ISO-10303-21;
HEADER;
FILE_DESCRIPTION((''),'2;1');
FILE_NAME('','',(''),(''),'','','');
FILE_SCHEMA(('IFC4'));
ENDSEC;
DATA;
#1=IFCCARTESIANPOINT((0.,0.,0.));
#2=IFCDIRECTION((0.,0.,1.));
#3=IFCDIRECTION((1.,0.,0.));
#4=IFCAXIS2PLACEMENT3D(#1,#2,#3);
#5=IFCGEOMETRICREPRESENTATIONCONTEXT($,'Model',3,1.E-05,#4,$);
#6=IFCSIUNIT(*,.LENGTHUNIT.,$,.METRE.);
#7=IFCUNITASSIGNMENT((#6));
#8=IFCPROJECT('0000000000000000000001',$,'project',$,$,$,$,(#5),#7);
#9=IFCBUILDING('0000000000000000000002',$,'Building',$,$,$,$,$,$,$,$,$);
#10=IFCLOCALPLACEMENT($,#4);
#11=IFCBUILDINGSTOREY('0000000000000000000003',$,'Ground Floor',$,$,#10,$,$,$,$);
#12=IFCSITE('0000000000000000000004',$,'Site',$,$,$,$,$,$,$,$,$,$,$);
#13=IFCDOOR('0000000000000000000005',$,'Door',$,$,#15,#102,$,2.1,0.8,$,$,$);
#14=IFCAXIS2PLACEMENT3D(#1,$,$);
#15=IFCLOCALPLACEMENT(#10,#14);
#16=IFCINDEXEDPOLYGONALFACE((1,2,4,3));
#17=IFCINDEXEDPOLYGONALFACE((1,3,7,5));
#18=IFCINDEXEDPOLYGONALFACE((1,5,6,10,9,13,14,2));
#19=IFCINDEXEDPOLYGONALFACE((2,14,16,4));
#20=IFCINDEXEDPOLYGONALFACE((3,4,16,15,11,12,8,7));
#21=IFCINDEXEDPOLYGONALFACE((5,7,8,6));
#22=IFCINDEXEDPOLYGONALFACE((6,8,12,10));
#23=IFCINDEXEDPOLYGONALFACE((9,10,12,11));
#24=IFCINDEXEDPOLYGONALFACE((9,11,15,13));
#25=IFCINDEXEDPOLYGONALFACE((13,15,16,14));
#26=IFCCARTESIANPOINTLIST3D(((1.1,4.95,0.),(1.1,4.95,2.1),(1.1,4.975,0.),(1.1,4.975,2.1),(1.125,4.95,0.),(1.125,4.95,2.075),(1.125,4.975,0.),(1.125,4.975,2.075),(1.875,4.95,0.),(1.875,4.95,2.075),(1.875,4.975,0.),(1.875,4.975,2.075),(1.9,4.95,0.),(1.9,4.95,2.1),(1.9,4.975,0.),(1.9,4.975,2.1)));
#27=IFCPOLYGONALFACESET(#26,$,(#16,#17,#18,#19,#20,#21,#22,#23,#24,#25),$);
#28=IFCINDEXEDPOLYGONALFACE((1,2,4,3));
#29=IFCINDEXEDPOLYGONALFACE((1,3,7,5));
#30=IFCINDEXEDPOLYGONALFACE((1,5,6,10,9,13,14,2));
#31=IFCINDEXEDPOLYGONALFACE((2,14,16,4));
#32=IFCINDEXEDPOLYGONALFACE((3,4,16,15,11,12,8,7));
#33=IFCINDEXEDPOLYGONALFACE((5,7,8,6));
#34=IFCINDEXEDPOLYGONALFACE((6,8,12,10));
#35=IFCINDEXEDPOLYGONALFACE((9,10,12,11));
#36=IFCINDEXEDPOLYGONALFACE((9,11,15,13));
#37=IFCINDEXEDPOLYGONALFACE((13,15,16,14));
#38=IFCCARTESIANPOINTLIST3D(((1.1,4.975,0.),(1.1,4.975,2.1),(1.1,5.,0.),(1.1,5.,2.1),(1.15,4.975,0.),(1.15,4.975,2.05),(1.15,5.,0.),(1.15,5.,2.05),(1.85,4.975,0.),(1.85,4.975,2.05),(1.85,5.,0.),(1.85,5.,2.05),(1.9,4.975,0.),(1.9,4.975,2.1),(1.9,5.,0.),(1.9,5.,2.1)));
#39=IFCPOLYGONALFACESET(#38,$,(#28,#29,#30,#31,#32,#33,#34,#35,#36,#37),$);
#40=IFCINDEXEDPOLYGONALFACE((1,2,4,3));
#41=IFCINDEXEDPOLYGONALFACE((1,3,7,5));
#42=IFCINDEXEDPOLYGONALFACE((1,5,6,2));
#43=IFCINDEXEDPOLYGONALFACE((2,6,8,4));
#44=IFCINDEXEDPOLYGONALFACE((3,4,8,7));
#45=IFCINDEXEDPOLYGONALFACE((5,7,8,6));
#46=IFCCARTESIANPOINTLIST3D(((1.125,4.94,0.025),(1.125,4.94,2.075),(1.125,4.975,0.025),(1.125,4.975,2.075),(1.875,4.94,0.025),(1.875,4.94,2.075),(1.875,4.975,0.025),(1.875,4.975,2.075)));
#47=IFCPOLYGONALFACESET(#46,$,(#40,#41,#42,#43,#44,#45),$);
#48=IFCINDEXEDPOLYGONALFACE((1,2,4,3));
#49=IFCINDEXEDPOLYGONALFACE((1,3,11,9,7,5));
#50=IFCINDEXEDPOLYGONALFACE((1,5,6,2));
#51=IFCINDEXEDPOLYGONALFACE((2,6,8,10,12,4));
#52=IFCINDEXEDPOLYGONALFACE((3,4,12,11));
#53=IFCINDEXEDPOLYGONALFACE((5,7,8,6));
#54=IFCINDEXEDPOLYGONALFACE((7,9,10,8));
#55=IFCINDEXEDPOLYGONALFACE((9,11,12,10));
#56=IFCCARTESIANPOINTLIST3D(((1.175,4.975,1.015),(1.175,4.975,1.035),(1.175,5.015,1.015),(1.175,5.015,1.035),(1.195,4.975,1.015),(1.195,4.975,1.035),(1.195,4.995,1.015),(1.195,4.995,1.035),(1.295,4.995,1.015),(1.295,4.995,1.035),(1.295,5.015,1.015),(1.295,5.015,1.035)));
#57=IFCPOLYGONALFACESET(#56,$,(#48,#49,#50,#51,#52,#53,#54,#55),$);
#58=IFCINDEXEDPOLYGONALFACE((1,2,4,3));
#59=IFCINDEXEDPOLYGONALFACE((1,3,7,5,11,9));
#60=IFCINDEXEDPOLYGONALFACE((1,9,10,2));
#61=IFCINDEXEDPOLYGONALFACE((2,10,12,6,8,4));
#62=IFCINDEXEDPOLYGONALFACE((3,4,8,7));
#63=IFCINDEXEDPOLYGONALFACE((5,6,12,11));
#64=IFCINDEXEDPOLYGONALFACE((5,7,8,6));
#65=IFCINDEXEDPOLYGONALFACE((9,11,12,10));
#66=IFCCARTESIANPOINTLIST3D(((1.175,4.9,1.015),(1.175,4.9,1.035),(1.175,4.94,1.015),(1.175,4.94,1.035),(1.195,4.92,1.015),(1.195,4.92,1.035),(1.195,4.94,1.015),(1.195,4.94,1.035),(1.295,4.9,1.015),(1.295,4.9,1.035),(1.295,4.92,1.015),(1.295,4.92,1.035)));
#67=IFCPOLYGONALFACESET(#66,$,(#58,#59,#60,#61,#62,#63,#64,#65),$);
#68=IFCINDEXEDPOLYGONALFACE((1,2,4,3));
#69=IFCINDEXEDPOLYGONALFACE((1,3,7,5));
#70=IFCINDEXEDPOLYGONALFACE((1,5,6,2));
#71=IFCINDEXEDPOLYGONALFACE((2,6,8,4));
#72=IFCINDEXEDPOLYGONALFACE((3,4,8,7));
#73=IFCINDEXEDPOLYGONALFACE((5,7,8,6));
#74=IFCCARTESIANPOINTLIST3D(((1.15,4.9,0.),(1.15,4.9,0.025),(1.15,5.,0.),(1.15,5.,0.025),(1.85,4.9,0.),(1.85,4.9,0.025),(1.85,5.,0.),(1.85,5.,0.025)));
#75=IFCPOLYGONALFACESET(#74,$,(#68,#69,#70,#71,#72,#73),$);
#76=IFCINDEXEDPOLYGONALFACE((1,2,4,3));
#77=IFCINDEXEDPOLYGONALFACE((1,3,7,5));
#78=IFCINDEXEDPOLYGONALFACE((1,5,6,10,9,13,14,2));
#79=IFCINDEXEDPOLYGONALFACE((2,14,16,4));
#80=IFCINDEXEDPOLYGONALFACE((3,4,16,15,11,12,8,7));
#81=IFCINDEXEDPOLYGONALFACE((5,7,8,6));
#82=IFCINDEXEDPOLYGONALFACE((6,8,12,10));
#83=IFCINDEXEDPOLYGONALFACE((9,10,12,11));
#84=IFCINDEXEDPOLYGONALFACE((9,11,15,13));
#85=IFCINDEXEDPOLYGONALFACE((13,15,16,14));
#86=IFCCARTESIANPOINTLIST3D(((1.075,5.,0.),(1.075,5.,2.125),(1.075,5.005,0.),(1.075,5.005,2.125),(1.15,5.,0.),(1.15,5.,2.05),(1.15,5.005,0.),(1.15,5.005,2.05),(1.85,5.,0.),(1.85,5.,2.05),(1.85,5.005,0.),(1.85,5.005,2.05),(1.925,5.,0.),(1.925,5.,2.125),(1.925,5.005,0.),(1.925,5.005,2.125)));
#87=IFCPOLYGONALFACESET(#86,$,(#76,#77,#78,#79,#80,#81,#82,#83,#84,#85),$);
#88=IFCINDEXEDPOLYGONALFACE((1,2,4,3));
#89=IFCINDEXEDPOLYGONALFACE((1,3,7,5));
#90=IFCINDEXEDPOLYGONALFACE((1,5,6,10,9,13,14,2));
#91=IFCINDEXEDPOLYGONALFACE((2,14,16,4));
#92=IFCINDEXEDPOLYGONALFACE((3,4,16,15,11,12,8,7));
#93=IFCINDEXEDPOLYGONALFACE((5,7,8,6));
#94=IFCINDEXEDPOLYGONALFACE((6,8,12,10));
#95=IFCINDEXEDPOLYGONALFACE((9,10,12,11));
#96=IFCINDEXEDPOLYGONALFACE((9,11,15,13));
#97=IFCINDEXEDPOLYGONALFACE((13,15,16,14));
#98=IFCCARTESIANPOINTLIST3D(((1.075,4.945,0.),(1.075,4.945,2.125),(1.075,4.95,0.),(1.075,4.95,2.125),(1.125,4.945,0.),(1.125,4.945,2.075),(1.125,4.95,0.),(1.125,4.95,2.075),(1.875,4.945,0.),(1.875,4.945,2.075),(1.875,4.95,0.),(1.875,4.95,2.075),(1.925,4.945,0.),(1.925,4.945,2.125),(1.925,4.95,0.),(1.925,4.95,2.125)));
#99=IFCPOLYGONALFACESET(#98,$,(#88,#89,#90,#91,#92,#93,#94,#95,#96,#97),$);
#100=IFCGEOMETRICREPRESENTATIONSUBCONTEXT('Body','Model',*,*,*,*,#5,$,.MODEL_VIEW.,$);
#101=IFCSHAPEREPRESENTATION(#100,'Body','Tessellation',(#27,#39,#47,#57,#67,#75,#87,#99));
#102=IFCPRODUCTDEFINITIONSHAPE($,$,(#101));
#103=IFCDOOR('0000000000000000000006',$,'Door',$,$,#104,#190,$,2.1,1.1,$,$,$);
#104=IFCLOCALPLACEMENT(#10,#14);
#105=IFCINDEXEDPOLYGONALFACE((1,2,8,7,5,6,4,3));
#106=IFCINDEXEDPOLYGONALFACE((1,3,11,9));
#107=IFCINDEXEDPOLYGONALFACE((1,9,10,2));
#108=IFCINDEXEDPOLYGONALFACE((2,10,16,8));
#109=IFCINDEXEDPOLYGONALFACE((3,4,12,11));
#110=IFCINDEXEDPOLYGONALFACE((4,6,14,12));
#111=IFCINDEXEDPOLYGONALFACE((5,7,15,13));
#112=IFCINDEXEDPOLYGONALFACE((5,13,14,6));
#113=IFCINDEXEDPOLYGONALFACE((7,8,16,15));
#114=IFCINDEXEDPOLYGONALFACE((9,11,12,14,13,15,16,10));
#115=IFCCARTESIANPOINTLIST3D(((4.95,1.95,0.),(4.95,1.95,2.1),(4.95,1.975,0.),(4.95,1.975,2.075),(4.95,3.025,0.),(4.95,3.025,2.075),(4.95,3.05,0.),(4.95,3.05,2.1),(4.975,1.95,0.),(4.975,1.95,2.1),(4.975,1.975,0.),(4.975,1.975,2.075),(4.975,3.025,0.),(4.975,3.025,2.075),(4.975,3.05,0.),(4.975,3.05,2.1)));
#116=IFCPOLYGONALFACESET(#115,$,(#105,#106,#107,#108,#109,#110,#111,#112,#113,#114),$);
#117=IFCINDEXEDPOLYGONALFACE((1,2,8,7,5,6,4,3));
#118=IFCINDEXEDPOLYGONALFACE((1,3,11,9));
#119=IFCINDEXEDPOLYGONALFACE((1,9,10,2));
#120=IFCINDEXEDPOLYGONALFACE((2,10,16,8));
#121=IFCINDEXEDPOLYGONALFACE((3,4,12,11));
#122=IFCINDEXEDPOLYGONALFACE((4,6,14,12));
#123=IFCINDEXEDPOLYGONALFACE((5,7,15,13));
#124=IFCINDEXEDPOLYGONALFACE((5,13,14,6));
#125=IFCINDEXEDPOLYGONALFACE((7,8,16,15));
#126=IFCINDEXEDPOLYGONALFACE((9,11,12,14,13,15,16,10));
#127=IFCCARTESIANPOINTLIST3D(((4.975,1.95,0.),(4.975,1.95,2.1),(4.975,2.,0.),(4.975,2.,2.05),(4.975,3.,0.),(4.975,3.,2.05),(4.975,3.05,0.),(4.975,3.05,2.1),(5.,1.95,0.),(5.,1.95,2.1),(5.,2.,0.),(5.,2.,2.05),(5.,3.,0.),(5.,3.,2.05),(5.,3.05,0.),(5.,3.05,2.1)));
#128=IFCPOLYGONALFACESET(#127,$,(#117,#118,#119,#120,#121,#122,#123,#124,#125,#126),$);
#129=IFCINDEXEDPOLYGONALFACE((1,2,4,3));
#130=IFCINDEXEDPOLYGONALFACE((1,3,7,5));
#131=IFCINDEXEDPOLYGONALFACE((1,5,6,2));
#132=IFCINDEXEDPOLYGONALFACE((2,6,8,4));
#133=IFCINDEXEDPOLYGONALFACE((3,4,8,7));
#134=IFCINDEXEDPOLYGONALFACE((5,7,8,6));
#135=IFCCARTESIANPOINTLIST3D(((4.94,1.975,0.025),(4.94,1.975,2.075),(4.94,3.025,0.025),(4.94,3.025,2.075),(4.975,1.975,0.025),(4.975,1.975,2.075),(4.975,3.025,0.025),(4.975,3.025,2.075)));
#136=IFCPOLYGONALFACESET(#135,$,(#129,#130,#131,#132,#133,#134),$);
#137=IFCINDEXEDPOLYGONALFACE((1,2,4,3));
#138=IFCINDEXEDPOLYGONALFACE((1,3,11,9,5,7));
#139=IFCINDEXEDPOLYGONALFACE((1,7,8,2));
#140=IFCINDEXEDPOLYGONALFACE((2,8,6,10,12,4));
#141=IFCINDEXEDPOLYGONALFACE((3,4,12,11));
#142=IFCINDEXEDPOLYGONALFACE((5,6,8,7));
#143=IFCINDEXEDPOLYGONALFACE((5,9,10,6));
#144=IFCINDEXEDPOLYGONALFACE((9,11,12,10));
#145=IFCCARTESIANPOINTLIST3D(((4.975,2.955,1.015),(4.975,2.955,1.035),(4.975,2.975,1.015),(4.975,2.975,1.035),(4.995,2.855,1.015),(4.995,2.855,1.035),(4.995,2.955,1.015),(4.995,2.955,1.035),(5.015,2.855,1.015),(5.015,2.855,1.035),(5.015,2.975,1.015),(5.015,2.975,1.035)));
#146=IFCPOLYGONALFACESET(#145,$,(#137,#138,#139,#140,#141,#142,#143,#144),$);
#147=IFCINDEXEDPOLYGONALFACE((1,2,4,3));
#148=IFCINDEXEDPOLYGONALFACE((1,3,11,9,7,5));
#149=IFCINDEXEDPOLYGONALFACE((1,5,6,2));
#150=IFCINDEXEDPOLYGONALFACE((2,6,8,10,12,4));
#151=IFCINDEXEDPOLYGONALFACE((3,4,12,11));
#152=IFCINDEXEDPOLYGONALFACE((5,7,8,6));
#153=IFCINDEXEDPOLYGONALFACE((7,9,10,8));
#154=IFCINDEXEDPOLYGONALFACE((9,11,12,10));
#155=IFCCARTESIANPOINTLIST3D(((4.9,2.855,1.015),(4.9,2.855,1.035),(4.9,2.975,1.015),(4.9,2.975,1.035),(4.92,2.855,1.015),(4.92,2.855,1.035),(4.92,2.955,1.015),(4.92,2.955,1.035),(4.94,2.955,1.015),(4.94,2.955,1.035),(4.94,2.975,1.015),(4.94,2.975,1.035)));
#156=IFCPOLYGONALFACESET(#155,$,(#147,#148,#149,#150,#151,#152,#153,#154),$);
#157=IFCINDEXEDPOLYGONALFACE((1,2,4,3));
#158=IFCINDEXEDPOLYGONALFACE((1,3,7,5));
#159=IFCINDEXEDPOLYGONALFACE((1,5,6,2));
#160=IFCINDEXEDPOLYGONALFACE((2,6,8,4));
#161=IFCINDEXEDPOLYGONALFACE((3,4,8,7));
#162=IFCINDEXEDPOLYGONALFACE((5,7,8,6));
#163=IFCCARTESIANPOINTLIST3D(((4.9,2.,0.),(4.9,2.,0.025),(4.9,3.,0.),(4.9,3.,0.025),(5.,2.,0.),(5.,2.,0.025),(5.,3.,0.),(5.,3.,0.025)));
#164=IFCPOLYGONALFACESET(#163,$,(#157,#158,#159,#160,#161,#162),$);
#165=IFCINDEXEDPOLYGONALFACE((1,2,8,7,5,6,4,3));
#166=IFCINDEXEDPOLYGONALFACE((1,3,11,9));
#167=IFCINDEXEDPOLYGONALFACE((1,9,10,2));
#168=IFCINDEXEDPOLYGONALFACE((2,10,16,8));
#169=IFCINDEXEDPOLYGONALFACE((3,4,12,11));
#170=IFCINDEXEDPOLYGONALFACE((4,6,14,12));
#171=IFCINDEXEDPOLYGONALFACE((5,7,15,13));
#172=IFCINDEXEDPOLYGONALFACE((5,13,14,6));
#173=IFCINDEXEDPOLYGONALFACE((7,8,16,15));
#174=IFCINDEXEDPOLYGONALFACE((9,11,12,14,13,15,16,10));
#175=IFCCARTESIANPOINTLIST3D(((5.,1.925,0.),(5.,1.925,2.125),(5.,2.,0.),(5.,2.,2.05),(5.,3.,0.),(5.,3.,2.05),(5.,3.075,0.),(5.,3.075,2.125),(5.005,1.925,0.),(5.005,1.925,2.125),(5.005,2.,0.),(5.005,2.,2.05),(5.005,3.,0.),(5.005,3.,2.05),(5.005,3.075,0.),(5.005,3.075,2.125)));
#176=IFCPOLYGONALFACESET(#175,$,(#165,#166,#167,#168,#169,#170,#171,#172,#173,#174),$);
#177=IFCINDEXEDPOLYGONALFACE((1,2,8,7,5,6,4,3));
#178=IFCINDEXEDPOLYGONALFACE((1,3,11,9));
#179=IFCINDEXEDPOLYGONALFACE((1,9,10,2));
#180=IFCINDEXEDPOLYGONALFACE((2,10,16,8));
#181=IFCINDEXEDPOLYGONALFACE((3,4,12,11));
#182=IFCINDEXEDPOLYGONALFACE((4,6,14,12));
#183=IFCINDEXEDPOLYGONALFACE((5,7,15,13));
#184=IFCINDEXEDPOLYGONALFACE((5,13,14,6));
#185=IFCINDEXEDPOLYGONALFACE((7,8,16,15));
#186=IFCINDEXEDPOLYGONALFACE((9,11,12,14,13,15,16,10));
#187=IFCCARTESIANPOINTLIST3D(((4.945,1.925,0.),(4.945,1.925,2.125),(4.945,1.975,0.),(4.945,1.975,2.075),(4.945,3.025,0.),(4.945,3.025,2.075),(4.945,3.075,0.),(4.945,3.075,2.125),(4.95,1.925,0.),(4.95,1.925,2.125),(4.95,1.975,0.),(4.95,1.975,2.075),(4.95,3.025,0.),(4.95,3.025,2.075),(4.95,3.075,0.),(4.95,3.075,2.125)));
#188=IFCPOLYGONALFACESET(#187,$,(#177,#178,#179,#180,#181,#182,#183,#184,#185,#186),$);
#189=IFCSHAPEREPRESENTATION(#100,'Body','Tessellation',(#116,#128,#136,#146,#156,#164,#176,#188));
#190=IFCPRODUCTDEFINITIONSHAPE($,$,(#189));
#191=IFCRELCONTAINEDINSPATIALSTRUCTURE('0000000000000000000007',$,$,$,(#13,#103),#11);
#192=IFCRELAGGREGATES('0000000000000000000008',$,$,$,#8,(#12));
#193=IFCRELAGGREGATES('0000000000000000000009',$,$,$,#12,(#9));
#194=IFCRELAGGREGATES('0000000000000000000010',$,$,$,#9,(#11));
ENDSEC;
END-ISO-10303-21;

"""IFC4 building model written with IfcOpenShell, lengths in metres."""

from ifc_helpers import new_model, si_unit, frame, origin_with_axes, place, context, subcontext, project, spatial, line, indexed_curve, outline, extrude, element, save


model = new_model("IFC4")

# Units and contexts
model_context = context("Model", 3, precision=1e-05, world=origin_with_axes())
body_context = subcontext(model_context, "Body", "Model", "MODEL_VIEW")
ifc_project = project(units=[si_unit("LENGTHUNIT", "METRE")], contexts=[model_context])

# Site, building, storey
site = spatial("IfcSite", under=ifc_project, Name="Site")
building = spatial("IfcBuilding", under=site, Name="Building")
storey_placement = place(None, origin_with_axes())
storey = spatial("IfcBuildingStorey", under=building, at=storey_placement, Name="Ground Floor")

# Doors
door_1_placement = place(storey_placement, frame((1.9, 5.0, 0.0), z_axis=(0.0, 0.0, 1.0), x_axis=(-1.0, 0.0, 0.0)))
element("IfcDoor", 1, at=door_1_placement, inside=storey, Name="Door", OverallHeight=2.1, OverallWidth=0.8, context=body_context, shape_type="SweptSolid", body=[
    extrude(outline(indexed_curve([(0.0, 0.0), (0.0, 2.1), (0.8, 2.1), (0.8, 0.0), (0.775, 0.0), (0.775, 2.075), (0.025, 2.075), (0.025, 0.0)], segments=[line(1, 2, 3, 4, 5, 6, 7, 8, 1)])), frame((0.0, 0.025, 0.0), z_axis=(0.0, -1.0, 0.0), x_axis=(1.0, 0.0, 0.0)), (0.0, 0.0, -1.0), 0.025),
    extrude(outline(indexed_curve([(0.0, 0.0), (0.0, 2.1), (0.8, 2.1), (0.8, 0.0), (0.75, 0.0), (0.75, 2.05), (0.05, 2.05), (0.05, 0.0)], segments=[line(1, 2, 3, 4, 5, 6, 7, 8, 1)])), frame((0.0, 0.0, 0.0), z_axis=(0.0, -1.0, 0.0), x_axis=(1.0, 0.0, 0.0)), (0.0, 0.0, -1.0), 0.025),
    extrude(outline(indexed_curve([(0.0, 0.0), (0.75, 0.0), (0.75, 0.035), (0.0, 0.035)], segments=[line(1, 2, 3, 4, 1)])), frame((0.025, 0.025, 0.025), z_axis=(0.0, 0.0, 1.0), x_axis=(1.0, 0.0, 0.0)), (0.0, 0.0, 1.0), 2.05),
    extrude(outline(indexed_curve([(0.0, 0.0), (0.0, -0.04), (-0.12, -0.04), (-0.12, -0.02), (-0.02, -0.02), (-0.02, 0.0)], segments=[line(1, 2, 3, 4, 5, 6, 1)])), frame((0.725, 0.025, 1.015), z_axis=(0.0, 0.0, 1.0), x_axis=(1.0, 0.0, 0.0)), (0.0, 0.0, 1.0), 0.02),
    extrude(outline(indexed_curve([(0.0, 0.0), (0.0, 0.04), (-0.12, 0.04), (-0.12, 0.02), (-0.02, 0.02), (-0.02, 0.0)], segments=[line(1, 2, 3, 4, 5, 6, 1)])), frame((0.725, 0.06, 1.015), z_axis=(0.0, 0.0, 1.0), x_axis=(1.0, 0.0, 0.0)), (0.0, 0.0, 1.0), 0.02),
    extrude(outline(indexed_curve([(0.0, 0.0), (0.7, 0.0), (0.7, 0.1), (0.0, 0.1)], segments=[line(1, 2, 3, 4, 1)])), frame((0.05, 0.0, 0.0), z_axis=(0.0, 0.0, 1.0), x_axis=(1.0, 0.0, 0.0)), (0.0, 0.0, 1.0), 0.025),
    extrude(outline(indexed_curve([(0.0, 0.0), (0.0, 2.125), (0.85, 2.125), (0.85, 0.0), (0.775, 0.0), (0.775, 2.05), (0.075, 2.05), (0.075, 0.0)], segments=[line(1, 2, 3, 4, 5, 6, 7, 8, 1)])), frame((-0.025, -0.005, 0.0), z_axis=(0.0, -1.0, 0.0), x_axis=(1.0, 0.0, 0.0)), (0.0, 0.0, -1.0), 0.005),
    extrude(outline(indexed_curve([(0.0, 0.0), (0.0, 2.125), (0.85, 2.125), (0.85, 0.0), (0.8, 0.0), (0.8, 2.075), (0.05, 2.075), (0.05, 0.0)], segments=[line(1, 2, 3, 4, 5, 6, 7, 8, 1)])), frame((-0.025, 0.05, 0.0), z_axis=(0.0, -1.0, 0.0), x_axis=(1.0, 0.0, 0.0)), (0.0, 0.0, -1.0), 0.005),
])
door_2_placement = place(storey_placement, frame((5.0, 1.95, 0.0), z_axis=(0.0, 0.0, 1.0), x_axis=(0.0, 1.0, 0.0)))
element("IfcDoor", 2, at=door_2_placement, inside=storey, Name="Door", OverallHeight=2.1, OverallWidth=1.1, context=body_context, shape_type="SweptSolid", body=[
    extrude(outline(indexed_curve([(0.0, 0.0), (0.0, 2.1), (1.1, 2.1), (1.1, 0.0), (1.075, 0.0), (1.075, 2.075), (0.025, 2.075), (0.025, 0.0)], segments=[line(1, 2, 3, 4, 5, 6, 7, 8, 1)])), frame((0.0, 0.025, 0.0), z_axis=(0.0, -1.0, 0.0), x_axis=(1.0, 0.0, 0.0)), (0.0, 0.0, -1.0), 0.025),
    extrude(outline(indexed_curve([(0.0, 0.0), (0.0, 2.1), (1.1, 2.1), (1.1, 0.0), (1.05, 0.0), (1.05, 2.05), (0.05, 2.05), (0.05, 0.0)], segments=[line(1, 2, 3, 4, 5, 6, 7, 8, 1)])), frame((0.0, 0.0, 0.0), z_axis=(0.0, -1.0, 0.0), x_axis=(1.0, 0.0, 0.0)), (0.0, 0.0, -1.0), 0.025),
    extrude(outline(indexed_curve([(0.0, 0.0), (1.05, 0.0), (1.05, 0.035), (0.0, 0.035)], segments=[line(1, 2, 3, 4, 1)])), frame((0.025, 0.025, 0.025), z_axis=(0.0, 0.0, 1.0), x_axis=(1.0, 0.0, 0.0)), (0.0, 0.0, 1.0), 2.05),
    extrude(outline(indexed_curve([(0.0, 0.0), (0.0, -0.04), (-0.12, -0.04), (-0.12, -0.02), (-0.02, -0.02), (-0.02, 0.0)], segments=[line(1, 2, 3, 4, 5, 6, 1)])), frame((1.025, 0.025, 1.015), z_axis=(0.0, 0.0, 1.0), x_axis=(1.0, 0.0, 0.0)), (0.0, 0.0, 1.0), 0.02),
    extrude(outline(indexed_curve([(0.0, 0.0), (0.0, 0.04), (-0.12, 0.04), (-0.12, 0.02), (-0.02, 0.02), (-0.02, 0.0)], segments=[line(1, 2, 3, 4, 5, 6, 1)])), frame((1.025, 0.06, 1.015), z_axis=(0.0, 0.0, 1.0), x_axis=(1.0, 0.0, 0.0)), (0.0, 0.0, 1.0), 0.02),
    extrude(outline(indexed_curve([(0.0, 0.0), (1.0, 0.0), (1.0, 0.1), (0.0, 0.1)], segments=[line(1, 2, 3, 4, 1)])), frame((0.05, 0.0, 0.0), z_axis=(0.0, 0.0, 1.0), x_axis=(1.0, 0.0, 0.0)), (0.0, 0.0, 1.0), 0.025),
    extrude(outline(indexed_curve([(0.0, 0.0), (0.0, 2.125), (1.15, 2.125), (1.15, 0.0), (1.075, 0.0), (1.075, 2.05), (0.075, 2.05), (0.075, 0.0)], segments=[line(1, 2, 3, 4, 5, 6, 7, 8, 1)])), frame((-0.025, -0.005, 0.0), z_axis=(0.0, -1.0, 0.0), x_axis=(1.0, 0.0, 0.0)), (0.0, 0.0, -1.0), 0.005),
    extrude(outline(indexed_curve([(0.0, 0.0), (0.0, 2.125), (1.15, 2.125), (1.15, 0.0), (1.1, 0.0), (1.1, 2.075), (0.05, 2.075), (0.05, 0.0)], segments=[line(1, 2, 3, 4, 5, 6, 7, 8, 1)])), frame((-0.025, 0.05, 0.0), z_axis=(0.0, -1.0, 0.0), x_axis=(1.0, 0.0, 0.0)), (0.0, 0.0, -1.0), 0.005),
])

save(model, "model.ifc")
